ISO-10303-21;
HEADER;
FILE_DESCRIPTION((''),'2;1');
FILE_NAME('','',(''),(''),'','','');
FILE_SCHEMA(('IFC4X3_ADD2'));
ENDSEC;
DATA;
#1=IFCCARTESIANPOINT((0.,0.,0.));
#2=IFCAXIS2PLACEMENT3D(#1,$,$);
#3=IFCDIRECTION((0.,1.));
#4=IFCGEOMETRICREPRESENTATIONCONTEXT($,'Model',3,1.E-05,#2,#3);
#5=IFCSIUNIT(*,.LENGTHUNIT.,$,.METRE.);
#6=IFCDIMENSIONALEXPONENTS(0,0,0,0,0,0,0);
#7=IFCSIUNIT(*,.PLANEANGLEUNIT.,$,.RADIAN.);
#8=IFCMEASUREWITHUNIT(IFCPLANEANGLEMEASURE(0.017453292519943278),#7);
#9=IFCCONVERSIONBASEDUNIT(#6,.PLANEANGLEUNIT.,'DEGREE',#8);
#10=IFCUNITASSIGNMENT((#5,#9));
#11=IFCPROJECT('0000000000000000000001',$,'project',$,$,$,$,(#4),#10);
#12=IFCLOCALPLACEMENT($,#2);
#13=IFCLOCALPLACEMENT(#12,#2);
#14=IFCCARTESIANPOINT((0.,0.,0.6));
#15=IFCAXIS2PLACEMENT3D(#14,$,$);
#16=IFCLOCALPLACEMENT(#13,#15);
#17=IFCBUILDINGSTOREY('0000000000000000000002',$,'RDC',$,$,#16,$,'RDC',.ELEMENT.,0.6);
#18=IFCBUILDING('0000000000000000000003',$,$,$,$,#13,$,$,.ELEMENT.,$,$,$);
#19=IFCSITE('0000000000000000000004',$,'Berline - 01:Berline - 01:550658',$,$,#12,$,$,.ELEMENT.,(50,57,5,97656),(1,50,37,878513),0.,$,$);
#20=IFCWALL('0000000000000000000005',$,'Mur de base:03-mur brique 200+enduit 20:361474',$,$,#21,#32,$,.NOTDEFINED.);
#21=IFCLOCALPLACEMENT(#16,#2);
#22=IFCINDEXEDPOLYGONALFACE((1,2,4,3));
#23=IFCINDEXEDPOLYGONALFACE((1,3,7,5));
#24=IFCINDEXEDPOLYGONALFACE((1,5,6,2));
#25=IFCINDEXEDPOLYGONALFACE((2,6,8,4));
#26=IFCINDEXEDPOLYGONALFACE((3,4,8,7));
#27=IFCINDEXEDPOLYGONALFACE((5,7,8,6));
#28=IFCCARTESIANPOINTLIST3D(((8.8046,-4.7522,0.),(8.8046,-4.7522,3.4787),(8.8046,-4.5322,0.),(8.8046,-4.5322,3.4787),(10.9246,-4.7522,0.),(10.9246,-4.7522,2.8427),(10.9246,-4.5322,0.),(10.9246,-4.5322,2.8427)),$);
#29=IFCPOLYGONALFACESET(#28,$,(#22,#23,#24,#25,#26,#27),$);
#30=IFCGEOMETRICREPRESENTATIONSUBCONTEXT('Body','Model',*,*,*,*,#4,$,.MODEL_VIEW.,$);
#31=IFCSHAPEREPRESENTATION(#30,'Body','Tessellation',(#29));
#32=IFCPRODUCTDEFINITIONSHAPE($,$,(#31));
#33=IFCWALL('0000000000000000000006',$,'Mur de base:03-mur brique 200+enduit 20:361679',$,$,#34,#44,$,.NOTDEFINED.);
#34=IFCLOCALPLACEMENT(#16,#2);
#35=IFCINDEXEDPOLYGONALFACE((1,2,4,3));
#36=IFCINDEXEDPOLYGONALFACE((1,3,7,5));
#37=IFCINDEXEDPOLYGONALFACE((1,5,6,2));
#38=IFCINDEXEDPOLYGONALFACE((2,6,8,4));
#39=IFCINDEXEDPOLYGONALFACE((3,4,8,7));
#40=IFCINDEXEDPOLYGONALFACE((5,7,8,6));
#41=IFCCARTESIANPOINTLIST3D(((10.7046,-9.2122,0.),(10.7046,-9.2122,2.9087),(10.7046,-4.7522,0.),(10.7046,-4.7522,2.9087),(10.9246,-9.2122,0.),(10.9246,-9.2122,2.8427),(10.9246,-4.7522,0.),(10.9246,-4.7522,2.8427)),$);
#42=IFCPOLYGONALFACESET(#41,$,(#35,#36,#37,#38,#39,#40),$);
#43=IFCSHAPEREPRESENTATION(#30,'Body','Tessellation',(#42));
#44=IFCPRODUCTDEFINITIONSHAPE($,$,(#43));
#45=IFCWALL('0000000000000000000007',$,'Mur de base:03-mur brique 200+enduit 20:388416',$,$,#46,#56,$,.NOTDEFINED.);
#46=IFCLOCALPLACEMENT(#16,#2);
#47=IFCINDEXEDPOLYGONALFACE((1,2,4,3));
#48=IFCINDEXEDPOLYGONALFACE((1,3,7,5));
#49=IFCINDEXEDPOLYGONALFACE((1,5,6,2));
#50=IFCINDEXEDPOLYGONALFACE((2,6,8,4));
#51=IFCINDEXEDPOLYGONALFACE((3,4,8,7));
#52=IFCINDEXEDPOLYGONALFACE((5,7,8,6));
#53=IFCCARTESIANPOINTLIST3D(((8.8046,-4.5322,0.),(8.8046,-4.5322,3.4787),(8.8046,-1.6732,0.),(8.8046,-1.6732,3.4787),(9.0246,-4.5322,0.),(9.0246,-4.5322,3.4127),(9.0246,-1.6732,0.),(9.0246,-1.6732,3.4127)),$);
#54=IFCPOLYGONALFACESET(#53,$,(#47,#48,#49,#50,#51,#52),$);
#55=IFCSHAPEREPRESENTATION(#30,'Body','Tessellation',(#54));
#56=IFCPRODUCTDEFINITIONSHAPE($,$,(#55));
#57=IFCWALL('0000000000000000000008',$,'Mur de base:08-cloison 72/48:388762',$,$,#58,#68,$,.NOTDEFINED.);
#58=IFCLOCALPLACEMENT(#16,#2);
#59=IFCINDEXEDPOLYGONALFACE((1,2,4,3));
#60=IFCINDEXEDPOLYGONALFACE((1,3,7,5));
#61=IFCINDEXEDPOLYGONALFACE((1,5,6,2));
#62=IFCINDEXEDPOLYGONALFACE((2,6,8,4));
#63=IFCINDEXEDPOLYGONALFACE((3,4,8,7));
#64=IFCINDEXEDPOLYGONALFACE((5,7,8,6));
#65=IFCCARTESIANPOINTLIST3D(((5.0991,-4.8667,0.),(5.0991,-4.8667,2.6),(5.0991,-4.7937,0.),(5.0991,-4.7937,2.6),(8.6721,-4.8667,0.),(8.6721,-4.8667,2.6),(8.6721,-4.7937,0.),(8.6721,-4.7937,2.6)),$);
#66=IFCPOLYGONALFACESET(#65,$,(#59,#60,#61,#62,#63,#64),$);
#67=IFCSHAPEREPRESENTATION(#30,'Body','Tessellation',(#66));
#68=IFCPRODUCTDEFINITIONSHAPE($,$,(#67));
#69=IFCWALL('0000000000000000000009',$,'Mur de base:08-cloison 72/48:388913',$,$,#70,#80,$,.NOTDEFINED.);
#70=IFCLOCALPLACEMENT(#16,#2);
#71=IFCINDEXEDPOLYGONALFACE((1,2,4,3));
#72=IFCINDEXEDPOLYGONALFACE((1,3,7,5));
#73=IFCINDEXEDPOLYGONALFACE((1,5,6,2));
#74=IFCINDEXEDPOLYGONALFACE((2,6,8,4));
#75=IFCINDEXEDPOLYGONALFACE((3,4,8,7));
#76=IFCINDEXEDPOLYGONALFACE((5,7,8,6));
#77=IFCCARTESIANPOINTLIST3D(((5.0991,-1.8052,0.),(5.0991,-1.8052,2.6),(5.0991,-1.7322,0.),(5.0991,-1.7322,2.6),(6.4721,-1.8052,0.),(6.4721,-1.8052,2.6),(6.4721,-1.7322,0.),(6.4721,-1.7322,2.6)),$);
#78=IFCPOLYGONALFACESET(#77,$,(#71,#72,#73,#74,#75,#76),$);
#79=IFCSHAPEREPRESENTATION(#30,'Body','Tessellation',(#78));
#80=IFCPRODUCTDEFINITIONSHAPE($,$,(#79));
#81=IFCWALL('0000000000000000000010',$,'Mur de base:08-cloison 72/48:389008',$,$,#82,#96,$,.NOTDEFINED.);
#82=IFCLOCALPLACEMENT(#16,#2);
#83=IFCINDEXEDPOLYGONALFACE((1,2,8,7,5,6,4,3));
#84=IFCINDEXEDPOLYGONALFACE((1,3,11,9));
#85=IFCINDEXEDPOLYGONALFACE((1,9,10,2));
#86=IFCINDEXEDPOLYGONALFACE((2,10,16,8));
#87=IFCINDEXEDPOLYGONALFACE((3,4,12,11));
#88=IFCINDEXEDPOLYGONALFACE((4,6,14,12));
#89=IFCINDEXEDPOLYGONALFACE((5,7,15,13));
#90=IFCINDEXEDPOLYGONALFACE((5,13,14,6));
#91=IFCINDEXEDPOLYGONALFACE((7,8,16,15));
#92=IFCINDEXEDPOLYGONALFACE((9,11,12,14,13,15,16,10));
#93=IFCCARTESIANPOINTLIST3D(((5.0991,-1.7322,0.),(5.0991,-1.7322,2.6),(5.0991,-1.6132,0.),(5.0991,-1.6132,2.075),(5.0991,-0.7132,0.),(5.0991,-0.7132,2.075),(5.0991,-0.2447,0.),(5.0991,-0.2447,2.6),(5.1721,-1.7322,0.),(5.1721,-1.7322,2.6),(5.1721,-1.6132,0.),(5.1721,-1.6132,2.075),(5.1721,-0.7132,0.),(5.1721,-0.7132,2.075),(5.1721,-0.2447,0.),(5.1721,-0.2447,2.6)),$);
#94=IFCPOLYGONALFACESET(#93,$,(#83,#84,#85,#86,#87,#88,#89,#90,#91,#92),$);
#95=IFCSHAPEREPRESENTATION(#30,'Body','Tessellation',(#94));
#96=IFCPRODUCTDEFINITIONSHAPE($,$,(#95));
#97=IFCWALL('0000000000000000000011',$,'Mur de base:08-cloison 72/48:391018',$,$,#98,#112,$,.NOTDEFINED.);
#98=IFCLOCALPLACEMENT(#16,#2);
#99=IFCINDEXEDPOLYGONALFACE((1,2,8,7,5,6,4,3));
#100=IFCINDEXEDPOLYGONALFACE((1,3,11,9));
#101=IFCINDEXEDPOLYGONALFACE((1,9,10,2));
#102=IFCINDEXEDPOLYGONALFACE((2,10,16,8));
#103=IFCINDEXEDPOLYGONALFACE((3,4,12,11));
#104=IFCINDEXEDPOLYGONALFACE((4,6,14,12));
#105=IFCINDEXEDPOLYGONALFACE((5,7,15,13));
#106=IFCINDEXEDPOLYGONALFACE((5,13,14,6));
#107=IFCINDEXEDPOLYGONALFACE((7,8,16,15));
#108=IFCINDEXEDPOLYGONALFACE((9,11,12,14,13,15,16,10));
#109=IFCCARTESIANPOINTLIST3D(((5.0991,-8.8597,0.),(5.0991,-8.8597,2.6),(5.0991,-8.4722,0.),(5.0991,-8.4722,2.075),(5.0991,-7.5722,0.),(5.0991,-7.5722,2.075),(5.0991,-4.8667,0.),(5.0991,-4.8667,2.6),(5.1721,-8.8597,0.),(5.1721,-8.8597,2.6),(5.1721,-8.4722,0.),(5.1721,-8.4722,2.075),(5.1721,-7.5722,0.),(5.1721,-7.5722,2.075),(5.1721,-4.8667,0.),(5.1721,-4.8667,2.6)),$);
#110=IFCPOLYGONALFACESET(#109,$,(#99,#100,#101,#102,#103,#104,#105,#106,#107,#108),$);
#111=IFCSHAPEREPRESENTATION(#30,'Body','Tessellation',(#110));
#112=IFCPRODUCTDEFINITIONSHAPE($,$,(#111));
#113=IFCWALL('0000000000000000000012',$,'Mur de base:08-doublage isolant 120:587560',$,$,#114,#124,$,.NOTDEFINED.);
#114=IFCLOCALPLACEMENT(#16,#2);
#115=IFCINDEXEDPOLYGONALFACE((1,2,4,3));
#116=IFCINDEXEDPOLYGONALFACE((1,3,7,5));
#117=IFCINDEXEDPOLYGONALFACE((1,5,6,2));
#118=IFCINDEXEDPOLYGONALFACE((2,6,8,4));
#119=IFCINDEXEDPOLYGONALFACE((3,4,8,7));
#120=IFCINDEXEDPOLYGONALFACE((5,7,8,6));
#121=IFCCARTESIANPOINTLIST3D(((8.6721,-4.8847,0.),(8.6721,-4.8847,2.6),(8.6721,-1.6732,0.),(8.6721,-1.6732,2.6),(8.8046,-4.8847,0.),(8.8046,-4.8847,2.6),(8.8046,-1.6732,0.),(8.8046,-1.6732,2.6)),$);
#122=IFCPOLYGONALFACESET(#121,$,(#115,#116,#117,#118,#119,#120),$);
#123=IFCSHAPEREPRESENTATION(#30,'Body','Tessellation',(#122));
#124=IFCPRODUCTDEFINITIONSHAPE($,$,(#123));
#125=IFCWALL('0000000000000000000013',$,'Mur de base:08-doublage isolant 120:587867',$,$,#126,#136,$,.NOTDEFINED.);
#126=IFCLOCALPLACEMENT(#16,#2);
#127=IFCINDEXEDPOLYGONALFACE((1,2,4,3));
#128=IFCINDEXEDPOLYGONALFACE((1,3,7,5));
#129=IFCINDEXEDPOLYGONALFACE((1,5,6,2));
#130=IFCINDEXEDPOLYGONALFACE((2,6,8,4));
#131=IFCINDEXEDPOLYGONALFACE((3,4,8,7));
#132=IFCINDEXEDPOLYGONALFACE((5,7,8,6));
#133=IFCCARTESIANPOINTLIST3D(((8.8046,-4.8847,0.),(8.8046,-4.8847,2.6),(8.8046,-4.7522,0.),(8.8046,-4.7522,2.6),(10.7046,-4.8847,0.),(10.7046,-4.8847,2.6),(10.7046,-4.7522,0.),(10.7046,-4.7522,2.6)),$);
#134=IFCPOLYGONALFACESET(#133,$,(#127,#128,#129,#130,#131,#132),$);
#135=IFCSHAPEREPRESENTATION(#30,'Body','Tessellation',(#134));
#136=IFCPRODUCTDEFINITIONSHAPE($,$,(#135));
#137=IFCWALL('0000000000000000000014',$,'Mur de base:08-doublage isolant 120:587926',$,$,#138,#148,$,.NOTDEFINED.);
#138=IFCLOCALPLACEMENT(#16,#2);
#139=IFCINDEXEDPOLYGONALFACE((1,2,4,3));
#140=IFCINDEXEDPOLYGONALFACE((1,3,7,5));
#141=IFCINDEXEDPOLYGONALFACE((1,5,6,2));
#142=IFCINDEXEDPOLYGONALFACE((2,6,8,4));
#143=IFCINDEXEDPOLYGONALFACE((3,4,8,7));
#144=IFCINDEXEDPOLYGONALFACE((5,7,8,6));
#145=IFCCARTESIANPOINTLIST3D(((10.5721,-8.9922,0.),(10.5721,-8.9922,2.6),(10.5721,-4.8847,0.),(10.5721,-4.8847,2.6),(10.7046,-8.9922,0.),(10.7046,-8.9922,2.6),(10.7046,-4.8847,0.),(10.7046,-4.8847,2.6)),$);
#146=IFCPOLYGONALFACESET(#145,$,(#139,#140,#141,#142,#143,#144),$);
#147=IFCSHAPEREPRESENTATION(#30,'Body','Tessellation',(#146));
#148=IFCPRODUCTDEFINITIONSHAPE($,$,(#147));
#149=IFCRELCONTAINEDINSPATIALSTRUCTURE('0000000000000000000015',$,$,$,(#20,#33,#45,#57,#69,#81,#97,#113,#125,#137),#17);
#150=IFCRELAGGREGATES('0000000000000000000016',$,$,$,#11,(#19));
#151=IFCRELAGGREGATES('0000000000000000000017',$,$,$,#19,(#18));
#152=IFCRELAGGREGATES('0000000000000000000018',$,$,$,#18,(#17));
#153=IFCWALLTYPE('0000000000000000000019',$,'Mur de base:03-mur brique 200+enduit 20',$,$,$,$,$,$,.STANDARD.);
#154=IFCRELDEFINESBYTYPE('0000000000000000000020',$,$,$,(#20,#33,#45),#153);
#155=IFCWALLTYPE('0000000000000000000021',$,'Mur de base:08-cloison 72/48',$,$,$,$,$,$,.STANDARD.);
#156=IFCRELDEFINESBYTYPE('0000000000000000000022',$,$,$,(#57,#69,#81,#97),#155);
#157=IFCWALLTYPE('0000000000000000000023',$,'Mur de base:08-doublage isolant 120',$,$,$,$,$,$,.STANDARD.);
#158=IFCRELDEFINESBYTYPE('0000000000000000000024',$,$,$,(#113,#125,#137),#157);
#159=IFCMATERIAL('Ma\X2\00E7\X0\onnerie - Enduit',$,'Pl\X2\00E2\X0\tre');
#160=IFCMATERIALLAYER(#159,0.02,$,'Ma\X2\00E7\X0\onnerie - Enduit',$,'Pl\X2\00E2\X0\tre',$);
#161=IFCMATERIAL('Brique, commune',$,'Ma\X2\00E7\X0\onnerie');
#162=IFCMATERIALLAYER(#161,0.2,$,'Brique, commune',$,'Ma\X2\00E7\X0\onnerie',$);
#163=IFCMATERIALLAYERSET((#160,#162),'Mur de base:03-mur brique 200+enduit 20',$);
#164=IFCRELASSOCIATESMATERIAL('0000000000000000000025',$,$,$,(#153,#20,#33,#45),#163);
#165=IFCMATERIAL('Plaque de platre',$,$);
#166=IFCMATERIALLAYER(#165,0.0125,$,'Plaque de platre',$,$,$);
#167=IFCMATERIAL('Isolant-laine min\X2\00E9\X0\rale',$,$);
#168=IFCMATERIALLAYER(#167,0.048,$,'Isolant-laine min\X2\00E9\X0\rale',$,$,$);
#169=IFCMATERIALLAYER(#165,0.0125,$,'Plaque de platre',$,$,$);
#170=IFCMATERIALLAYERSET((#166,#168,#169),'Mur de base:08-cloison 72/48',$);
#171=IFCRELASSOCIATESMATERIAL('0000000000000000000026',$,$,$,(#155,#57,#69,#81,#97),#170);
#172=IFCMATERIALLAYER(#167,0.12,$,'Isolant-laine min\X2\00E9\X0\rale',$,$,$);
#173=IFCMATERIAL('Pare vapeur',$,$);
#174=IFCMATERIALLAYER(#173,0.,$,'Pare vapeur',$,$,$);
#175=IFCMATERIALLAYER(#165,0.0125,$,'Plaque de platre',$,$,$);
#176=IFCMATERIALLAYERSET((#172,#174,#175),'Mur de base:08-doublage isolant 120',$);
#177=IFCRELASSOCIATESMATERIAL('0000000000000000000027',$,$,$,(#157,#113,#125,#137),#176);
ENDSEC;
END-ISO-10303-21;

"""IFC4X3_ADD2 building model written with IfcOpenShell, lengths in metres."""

from ifc_helpers import new_model, entity, si_unit, converted_unit, direction, frame, frame_2d, origin, place, context, subcontext, project, spatial, polyline, rectangle, extrude, clip, bounded_halfspace, material, layer, layer_set, type_object, element, save


model = new_model("IFC4X3_ADD2")

# Units and contexts
model_context = context("Model", 3, precision=1e-05, world=origin(), true_north=direction((0.0, 1.0)))
body_context = subcontext(model_context, "Body", "Model", "MODEL_VIEW")
ifc_project = project(units=[si_unit("LENGTHUNIT", "METRE"), converted_unit("PLANEANGLEUNIT", "DEGREE", entity("IfcPlaneAngleMeasure", 0.017453292519943278), si_unit("PLANEANGLEUNIT", "RADIAN"), dimensions=[0, 0, 0, 0, 0, 0, 0])], contexts=[model_context])

# Site, building, storey
site_placement = place(None, origin())
site = spatial("IfcSite", under=ifc_project, at=site_placement, Name="Berline - 01:Berline - 01:550658", CompositionType="ELEMENT", RefLatitude=(50, 57, 5, 97656), RefLongitude=(1, 50, 37, 878513), RefElevation=0.0)
building_placement = place(site_placement, origin())
building = spatial("IfcBuilding", under=site, at=building_placement, CompositionType="ELEMENT")
storey_placement = place(building_placement, frame((0.0, 0.0, 0.6)))
storey = spatial("IfcBuildingStorey", under=building, at=storey_placement, Name="RDC", LongName="RDC", CompositionType="ELEMENT", Elevation=0.6)

# Walls
ifc_material_1 = material(Name="Maçonnerie - Enduit", Category="Plâtre")
ifc_layer_1 = layer(ifc_material_1, 0.02, Name="Maçonnerie - Enduit", Category="Plâtre")
ifc_material_2 = material(Name="Brique, commune", Category="Maçonnerie")
ifc_layer_2 = layer(ifc_material_2, 0.2, Name="Brique, commune", Category="Maçonnerie")
ifc_layer_set_1 = layer_set([ifc_layer_1, ifc_layer_2], Name="Mur de base:03-mur brique 200+enduit 20")
wall_type_1 = type_object("IfcWallType", Name="Mur de base:03-mur brique 200+enduit 20", PredefinedType="STANDARD", material=ifc_layer_set_1)
wall_1_placement = place(storey_placement, frame((8.8046, -4.6422, 0.0)))
element("IfcWall", 1, at=wall_1_placement, inside=storey, type_object=wall_type_1, material=ifc_layer_set_1, Name="Mur de base:03-mur brique 200+enduit 20:361474", PredefinedType="NOTDEFINED", context=body_context, shape_type="Clipping", body=[
    clip(extrude(rectangle(XDim=2.12, YDim=0.22, at=frame_2d((1.06, 0.0), x_axis=(-1.0, 0.0))), origin(), (0.0, 0.0, 1.0), 3.4787), bounded_halfspace(frame((0.0, -0.11, 3.4787), z_axis=(0.287361, 0.0, 0.957822), x_axis=(0.0, 1.0, 0.0)), False, frame((0.0, -0.11, 3.4787)), polyline([(0.0, 0.0), (1.9, 0.0), (2.12, 0.0), (2.12, 0.22), (0.22, 0.22), (0.0, 0.22), (0.0, 0.0)]))),
])
wall_2_placement = place(storey_placement, frame((10.8146, -4.7522, 0.0), z_axis=(0.0, 0.0, 1.0), x_axis=(0.0, -1.0, 0.0)))
element("IfcWall", 2, at=wall_2_placement, inside=storey, type_object=wall_type_1, material=ifc_layer_set_1, Name="Mur de base:03-mur brique 200+enduit 20:361679", PredefinedType="NOTDEFINED", context=body_context, shape_type="Clipping", body=[
    clip(extrude(rectangle(XDim=4.46, YDim=0.22, at=frame_2d((2.23, 0.0), x_axis=(-1.0, 0.0))), origin(), (0.0, 0.0, 1.0), 2.9087), bounded_halfspace(frame((0.0, -0.11, 2.9087), z_axis=(0.0, 0.287361, 0.957822), x_axis=(-1.0, 0.0, 0.0)), False, frame((0.0, -0.11, 2.9087)), polyline([(0.0, 0.0), (4.24, 0.0), (4.46, 0.0), (4.46, 0.22), (0.0, 0.22), (0.0, 0.0)]))),
])
wall_3_placement = place(storey_placement, frame((8.9146, -1.6732, 0.0), z_axis=(0.0, 0.0, 1.0), x_axis=(0.0, -1.0, 0.0)))
element("IfcWall", 3, at=wall_3_placement, inside=storey, type_object=wall_type_1, material=ifc_layer_set_1, Name="Mur de base:03-mur brique 200+enduit 20:388416", PredefinedType="NOTDEFINED", context=body_context, shape_type="Clipping", body=[
    clip(extrude(rectangle(XDim=2.859, YDim=0.22, at=frame_2d((1.4295, 0.0), x_axis=(-1.0, 0.0))), origin(), (0.0, 0.0, 1.0), 3.4787), bounded_halfspace(frame((0.0, -0.11, 3.4787), z_axis=(0.0, 0.287361, 0.957822), x_axis=(-1.0, 0.0, 0.0)), False, frame((0.0, -0.11, 3.4787)), polyline([(0.0, 0.0), (2.859, 0.0), (2.859, 0.22), (0.0, 0.22), (0.0, 0.0)]))),
])
ifc_material_3 = material(Name="Plaque de platre")
ifc_layer_3 = layer(ifc_material_3, 0.0125, Name="Plaque de platre")
ifc_material_4 = material(Name="Isolant-laine minérale")
ifc_layer_4 = layer(ifc_material_4, 0.048, Name="Isolant-laine minérale")
ifc_layer_5 = layer(ifc_material_3, 0.0125, Name="Plaque de platre")
ifc_layer_set_2 = layer_set([ifc_layer_3, ifc_layer_4, ifc_layer_5], Name="Mur de base:08-cloison 72/48")
wall_type_2 = type_object("IfcWallType", Name="Mur de base:08-cloison 72/48", PredefinedType="STANDARD", material=ifc_layer_set_2)
wall_4_placement = place(storey_placement, frame((8.6721, -4.8302, 0.0), z_axis=(0.0, 0.0, 1.0), x_axis=(-1.0, 0.0, 0.0)))
element("IfcWall", 4, at=wall_4_placement, inside=storey, type_object=wall_type_2, material=ifc_layer_set_2, Name="Mur de base:08-cloison 72/48:388762", PredefinedType="NOTDEFINED", context=body_context, shape_type="SweptSolid", body=[
    extrude(rectangle(XDim=3.573, YDim=0.073, at=frame_2d((1.7865, 0.0), x_axis=(-1.0, 0.0))), origin(), (0.0, 0.0, 1.0), 2.6),
])
wall_5_placement = place(storey_placement, frame((6.4721, -1.7687, 0.0), z_axis=(0.0, 0.0, 1.0), x_axis=(-1.0, 0.0, 0.0)))
element("IfcWall", 5, at=wall_5_placement, inside=storey, type_object=wall_type_2, material=ifc_layer_set_2, Name="Mur de base:08-cloison 72/48:388913", PredefinedType="NOTDEFINED", context=body_context, shape_type="SweptSolid", body=[
    extrude(rectangle(XDim=1.373, YDim=0.073, at=frame_2d((0.6865, 0.0), x_axis=(-1.0, 0.0))), origin(), (0.0, 0.0, 1.0), 2.6),
])

# Walls, openings
wall_6_placement = place(storey_placement, frame((5.1356, -0.2447, 0.0), z_axis=(0.0, 0.0, 1.0), x_axis=(0.0, -1.0, 0.0)))
wall_6 = element("IfcWall", 6, at=wall_6_placement, inside=storey, type_object=wall_type_2, material=ifc_layer_set_2, Name="Mur de base:08-cloison 72/48:389008", PredefinedType="NOTDEFINED", context=body_context, shape_type="SweptSolid", body=[
    extrude(rectangle(XDim=1.4875, YDim=0.073, at=frame_2d((0.7437, 0.0), x_axis=(-1.0, 0.0))), origin(), (0.0, 0.0, 1.0), 2.6),
])
opening_1_placement = place(wall_6_placement, frame((0.4685, -0.0365, 0.0)))
element("IfcOpeningElement", 7, at=opening_1_placement, cuts=wall_6, PredefinedType="OPENING", context=body_context, shape_type="SweptSolid", body=[
    extrude(rectangle(XDim=2.075, YDim=0.9, at=frame_2d((1.0375, 0.45), x_axis=(1.0, 0.0))), frame((0.0, 0.0, 0.0), z_axis=(0.0, 1.0, 0.0), x_axis=(0.0, 0.0, 1.0)), (0.0, 0.0, 1.0), 0.073),
])
wall_7_placement = place(storey_placement, frame((5.1356, -4.8667, 0.0), z_axis=(0.0, 0.0, 1.0), x_axis=(0.0, -1.0, 0.0)))
wall_7 = element("IfcWall", 8, at=wall_7_placement, inside=storey, type_object=wall_type_2, material=ifc_layer_set_2, Name="Mur de base:08-cloison 72/48:391018", PredefinedType="NOTDEFINED", context=body_context, shape_type="SweptSolid", body=[
    extrude(rectangle(XDim=3.993, YDim=0.073, at=frame_2d((1.9965, 0.0), x_axis=(-1.0, 0.0))), origin(), (0.0, 0.0, 1.0), 2.6),
])
opening_2_placement = place(wall_7_placement, frame((2.7055, -0.0365, 0.0)))
element("IfcOpeningElement", 9, at=opening_2_placement, cuts=wall_7, PredefinedType="OPENING", context=body_context, shape_type="SweptSolid", body=[
    extrude(rectangle(XDim=2.075, YDim=0.9, at=frame_2d((1.0375, 0.45), x_axis=(1.0, 0.0))), frame((0.0, 0.0, 0.0), z_axis=(0.0, 1.0, 0.0), x_axis=(0.0, 0.0, 1.0)), (0.0, 0.0, 1.0), 0.073),
])

# Walls
ifc_layer_6 = layer(ifc_material_4, 0.12, Name="Isolant-laine minérale")
ifc_material_5 = material(Name="Pare vapeur")
ifc_layer_7 = layer(ifc_material_5, 0.0, Name="Pare vapeur")
ifc_layer_8 = layer(ifc_material_3, 0.0125, Name="Plaque de platre")
ifc_layer_set_3 = layer_set([ifc_layer_6, ifc_layer_7, ifc_layer_8], Name="Mur de base:08-doublage isolant 120")
wall_type_3 = type_object("IfcWallType", Name="Mur de base:08-doublage isolant 120", PredefinedType="STANDARD", material=ifc_layer_set_3)
wall_8_placement = place(storey_placement, frame((8.7383, -1.6732, 0.0), z_axis=(0.0, 0.0, 1.0), x_axis=(0.0, -1.0, 0.0)))
element("IfcWall", 10, at=wall_8_placement, inside=storey, type_object=wall_type_3, material=ifc_layer_set_3, Name="Mur de base:08-doublage isolant 120:587560", PredefinedType="NOTDEFINED", context=body_context, shape_type="SweptSolid", body=[
    extrude(rectangle(XDim=3.2115, YDim=0.1325, at=frame_2d((1.6057, 0.0), x_axis=(-1.0, 0.0))), origin(), (0.0, 0.0, 1.0), 2.6),
])
wall_9_placement = place(storey_placement, frame((8.8046, -4.8185, 0.0)))
element("IfcWall", 11, at=wall_9_placement, inside=storey, type_object=wall_type_3, material=ifc_layer_set_3, Name="Mur de base:08-doublage isolant 120:587867", PredefinedType="NOTDEFINED", context=body_context, shape_type="SweptSolid", body=[
    extrude(rectangle(XDim=1.9, YDim=0.1325, at=frame_2d((0.95, 0.0), x_axis=(-1.0, 0.0))), origin(), (0.0, 0.0, 1.0), 2.6),
])
wall_10_placement = place(storey_placement, frame((10.6383, -4.8847, 0.0), z_axis=(0.0, 0.0, 1.0), x_axis=(0.0, -1.0, 0.0)))
element("IfcWall", 12, at=wall_10_placement, inside=storey, type_object=wall_type_3, material=ifc_layer_set_3, Name="Mur de base:08-doublage isolant 120:587926", PredefinedType="NOTDEFINED", context=body_context, shape_type="SweptSolid", body=[
    extrude(rectangle(XDim=4.1075, YDim=0.1325, at=frame_2d((2.0538, 0.0), x_axis=(-1.0, 0.0))), origin(), (0.0, 0.0, 1.0), 2.6),
])

save(model, "model.ifc")
